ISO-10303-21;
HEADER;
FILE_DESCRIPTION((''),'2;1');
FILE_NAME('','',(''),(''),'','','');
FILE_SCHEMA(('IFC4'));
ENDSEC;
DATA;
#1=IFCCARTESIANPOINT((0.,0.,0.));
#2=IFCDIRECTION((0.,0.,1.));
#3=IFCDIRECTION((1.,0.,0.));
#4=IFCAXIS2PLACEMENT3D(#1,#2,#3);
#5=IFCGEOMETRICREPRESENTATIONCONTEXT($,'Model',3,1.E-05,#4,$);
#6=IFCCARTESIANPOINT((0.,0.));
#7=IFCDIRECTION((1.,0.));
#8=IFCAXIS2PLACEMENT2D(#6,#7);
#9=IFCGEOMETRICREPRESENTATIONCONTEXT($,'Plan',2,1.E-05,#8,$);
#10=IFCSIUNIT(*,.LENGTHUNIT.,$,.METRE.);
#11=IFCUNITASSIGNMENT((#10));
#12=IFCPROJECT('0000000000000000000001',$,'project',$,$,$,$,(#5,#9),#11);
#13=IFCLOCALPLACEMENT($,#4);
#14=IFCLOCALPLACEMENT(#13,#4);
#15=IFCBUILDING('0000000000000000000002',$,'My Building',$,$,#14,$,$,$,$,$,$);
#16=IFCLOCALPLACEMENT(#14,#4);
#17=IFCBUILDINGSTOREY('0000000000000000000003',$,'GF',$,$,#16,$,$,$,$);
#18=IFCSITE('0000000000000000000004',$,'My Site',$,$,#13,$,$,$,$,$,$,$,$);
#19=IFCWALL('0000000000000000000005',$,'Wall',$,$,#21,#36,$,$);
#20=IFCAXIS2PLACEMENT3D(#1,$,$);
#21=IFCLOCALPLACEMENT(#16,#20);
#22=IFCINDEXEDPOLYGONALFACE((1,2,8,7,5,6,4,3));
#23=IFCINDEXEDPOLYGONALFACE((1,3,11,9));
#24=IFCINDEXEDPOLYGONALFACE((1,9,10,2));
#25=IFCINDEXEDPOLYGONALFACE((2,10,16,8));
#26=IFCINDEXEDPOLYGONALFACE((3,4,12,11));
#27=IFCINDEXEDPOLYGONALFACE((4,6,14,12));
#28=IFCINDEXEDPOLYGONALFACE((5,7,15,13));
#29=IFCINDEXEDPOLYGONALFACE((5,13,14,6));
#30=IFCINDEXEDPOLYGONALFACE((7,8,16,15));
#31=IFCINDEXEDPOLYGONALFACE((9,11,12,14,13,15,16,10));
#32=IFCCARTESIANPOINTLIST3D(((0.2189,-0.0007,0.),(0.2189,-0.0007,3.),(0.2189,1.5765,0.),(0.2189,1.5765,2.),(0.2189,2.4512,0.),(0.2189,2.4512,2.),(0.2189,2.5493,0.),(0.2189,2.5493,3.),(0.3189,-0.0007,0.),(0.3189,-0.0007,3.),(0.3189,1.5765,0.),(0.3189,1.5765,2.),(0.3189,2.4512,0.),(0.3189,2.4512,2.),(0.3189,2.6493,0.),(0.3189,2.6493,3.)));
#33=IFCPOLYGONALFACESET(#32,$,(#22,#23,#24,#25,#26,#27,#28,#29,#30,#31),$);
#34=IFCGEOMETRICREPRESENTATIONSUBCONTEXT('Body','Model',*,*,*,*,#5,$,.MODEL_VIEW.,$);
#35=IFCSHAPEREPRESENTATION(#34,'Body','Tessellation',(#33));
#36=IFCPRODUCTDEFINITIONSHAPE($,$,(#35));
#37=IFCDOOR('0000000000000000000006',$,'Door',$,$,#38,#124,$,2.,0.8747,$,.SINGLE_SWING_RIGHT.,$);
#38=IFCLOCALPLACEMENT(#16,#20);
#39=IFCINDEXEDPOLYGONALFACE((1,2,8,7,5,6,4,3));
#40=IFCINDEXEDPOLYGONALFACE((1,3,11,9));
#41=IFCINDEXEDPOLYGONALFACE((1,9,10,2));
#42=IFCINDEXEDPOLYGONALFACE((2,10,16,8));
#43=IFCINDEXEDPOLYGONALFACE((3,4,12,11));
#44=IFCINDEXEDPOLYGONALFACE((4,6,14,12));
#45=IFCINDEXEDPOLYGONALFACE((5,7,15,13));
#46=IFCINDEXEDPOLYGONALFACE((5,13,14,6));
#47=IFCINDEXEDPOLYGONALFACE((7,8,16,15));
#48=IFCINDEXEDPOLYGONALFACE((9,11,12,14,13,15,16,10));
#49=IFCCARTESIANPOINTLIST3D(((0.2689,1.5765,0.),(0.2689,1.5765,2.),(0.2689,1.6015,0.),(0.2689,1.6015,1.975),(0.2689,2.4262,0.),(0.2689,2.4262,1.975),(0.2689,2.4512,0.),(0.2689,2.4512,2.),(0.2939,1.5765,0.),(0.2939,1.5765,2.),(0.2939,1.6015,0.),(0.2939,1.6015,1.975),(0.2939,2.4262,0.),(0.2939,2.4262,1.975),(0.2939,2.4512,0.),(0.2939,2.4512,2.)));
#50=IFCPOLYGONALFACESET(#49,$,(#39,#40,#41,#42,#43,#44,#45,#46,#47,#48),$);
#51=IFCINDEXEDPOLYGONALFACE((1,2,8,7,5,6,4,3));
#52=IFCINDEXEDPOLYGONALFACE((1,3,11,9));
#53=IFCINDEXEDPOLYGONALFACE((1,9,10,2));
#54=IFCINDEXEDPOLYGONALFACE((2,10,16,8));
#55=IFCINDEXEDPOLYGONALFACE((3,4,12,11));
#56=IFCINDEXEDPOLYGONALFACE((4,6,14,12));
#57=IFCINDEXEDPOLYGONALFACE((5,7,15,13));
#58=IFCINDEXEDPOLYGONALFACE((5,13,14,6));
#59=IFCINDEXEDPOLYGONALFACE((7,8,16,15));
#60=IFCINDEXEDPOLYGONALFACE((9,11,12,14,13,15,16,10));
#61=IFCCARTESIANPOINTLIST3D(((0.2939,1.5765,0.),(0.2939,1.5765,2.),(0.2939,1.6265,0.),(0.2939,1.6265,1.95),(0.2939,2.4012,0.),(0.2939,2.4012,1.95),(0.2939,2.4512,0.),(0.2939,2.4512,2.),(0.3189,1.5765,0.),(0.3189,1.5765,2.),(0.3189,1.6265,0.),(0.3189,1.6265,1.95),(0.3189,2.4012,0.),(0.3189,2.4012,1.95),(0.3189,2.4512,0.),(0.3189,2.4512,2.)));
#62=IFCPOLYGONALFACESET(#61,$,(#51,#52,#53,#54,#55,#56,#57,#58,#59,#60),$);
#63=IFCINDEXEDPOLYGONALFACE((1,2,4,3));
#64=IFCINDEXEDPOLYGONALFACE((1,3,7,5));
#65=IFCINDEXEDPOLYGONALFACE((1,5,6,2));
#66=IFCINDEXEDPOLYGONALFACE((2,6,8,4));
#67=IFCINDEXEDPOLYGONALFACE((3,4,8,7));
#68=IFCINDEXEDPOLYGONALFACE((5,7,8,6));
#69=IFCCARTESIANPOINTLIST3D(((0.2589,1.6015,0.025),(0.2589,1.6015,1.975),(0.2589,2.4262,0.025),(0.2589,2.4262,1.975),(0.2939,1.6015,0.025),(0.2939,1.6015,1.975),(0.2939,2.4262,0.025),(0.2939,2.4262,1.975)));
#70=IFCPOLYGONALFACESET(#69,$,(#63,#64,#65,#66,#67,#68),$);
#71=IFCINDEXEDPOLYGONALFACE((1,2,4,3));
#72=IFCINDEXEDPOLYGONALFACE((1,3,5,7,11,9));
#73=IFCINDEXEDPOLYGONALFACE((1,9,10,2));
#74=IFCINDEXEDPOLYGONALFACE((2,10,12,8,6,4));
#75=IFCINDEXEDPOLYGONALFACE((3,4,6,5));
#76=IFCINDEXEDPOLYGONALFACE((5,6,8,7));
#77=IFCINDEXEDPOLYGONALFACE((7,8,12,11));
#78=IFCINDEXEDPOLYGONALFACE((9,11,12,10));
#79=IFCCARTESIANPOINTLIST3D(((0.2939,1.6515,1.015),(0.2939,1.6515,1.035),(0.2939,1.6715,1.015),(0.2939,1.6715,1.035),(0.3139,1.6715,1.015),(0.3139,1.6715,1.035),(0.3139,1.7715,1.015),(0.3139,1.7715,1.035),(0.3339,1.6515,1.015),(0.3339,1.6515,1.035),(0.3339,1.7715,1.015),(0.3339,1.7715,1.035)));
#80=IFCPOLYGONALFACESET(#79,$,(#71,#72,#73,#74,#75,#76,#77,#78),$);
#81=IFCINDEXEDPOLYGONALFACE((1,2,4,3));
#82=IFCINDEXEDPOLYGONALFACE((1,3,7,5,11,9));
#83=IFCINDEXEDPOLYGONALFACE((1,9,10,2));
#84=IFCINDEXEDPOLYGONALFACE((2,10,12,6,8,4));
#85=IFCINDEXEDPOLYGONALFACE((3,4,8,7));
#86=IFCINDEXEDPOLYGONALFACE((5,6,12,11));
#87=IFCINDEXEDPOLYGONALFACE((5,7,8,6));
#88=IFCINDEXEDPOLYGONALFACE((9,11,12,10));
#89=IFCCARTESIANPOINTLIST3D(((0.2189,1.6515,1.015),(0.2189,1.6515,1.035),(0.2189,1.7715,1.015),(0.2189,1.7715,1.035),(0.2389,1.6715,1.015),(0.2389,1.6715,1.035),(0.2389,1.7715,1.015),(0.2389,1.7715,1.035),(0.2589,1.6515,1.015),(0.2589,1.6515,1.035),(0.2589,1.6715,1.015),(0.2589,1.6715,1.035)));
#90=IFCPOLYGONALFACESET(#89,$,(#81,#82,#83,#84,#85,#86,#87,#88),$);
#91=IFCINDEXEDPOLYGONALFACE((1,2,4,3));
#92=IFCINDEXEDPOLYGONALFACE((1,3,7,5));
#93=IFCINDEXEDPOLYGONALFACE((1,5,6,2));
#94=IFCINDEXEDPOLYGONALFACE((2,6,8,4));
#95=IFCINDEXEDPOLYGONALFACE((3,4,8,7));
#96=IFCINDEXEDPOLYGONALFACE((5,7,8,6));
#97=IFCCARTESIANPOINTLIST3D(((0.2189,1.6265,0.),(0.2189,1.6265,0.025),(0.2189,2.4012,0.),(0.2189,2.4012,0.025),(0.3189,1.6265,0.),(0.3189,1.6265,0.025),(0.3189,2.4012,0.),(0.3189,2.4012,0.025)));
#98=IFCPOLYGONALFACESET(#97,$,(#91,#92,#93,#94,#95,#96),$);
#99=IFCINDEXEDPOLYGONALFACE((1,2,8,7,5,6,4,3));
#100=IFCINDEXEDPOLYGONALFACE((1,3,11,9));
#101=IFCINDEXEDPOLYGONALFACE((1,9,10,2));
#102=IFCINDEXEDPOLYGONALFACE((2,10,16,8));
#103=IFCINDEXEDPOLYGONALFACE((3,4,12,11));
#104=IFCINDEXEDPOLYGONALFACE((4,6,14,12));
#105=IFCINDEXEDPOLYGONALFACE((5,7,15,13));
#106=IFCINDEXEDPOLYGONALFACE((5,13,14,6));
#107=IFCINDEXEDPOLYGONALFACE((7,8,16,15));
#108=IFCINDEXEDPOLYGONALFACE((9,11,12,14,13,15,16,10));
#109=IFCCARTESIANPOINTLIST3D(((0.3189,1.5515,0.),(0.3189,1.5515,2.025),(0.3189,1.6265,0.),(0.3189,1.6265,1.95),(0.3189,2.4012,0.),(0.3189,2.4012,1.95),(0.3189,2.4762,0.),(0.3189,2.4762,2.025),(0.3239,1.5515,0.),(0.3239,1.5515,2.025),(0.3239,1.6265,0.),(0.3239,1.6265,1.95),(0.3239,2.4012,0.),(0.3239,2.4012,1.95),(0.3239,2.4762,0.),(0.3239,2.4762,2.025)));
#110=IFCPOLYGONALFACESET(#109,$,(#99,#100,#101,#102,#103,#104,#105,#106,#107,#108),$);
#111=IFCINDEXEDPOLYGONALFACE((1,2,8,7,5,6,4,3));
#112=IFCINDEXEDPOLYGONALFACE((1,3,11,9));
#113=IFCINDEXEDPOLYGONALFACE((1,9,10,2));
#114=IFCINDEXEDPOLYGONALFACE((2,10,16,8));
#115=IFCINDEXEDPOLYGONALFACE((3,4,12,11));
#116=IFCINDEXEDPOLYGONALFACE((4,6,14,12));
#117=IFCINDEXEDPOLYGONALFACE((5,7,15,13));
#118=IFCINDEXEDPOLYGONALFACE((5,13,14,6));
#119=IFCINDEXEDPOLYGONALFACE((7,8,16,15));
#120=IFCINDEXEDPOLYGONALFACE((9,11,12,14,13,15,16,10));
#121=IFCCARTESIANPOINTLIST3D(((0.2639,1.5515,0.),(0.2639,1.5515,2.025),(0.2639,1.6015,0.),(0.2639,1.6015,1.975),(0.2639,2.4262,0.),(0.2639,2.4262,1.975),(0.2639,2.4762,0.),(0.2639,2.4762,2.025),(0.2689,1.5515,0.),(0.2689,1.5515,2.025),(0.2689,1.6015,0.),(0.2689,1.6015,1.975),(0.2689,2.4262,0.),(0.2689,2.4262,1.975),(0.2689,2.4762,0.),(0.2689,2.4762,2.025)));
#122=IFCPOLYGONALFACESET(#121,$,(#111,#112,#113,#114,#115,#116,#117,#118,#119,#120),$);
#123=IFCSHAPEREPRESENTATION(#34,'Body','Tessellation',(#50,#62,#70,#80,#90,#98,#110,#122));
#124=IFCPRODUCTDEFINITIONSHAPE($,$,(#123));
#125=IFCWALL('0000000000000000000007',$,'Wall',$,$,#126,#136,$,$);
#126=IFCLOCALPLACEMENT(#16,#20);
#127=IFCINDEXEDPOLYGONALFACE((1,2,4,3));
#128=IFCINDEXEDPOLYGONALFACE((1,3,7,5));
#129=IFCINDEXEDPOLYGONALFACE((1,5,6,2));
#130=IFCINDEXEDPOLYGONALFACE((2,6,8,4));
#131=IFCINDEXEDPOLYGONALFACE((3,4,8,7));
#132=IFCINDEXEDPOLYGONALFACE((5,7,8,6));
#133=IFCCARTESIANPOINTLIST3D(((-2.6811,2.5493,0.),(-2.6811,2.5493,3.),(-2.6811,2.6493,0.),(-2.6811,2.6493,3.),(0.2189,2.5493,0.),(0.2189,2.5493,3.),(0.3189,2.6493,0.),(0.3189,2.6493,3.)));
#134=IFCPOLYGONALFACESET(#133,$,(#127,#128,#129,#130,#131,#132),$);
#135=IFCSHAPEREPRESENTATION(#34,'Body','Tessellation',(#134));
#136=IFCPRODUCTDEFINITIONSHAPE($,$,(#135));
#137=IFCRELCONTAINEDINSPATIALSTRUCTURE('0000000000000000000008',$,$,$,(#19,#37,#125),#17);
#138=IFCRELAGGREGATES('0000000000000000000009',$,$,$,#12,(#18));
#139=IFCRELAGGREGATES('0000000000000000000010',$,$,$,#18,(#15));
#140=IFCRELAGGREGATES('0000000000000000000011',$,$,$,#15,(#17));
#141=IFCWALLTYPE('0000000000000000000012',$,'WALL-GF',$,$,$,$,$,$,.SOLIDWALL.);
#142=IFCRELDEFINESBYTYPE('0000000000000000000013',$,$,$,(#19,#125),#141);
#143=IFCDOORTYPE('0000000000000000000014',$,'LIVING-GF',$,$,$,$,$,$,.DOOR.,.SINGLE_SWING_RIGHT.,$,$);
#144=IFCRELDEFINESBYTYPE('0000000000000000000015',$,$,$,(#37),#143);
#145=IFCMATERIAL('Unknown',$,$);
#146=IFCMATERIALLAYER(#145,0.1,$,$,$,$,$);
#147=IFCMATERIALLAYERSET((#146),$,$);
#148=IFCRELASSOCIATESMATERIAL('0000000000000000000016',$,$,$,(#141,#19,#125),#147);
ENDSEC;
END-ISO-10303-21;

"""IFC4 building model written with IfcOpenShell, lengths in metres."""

from ifc_helpers import new_model, entity, si_unit, frame, origin_with_axes, origin_2d_with_axis, place, context, subcontext, project, spatial, line, indexed_curve, outline, extrude, shape, source, transform, mapped, material, layer, layer_set, layer_usage, type_object, type_shapes, element, fill, save


model = new_model("IFC4")

# Units and contexts
model_context = context("Model", 3, precision=1e-05, world=origin_with_axes())
plan_context = context("Plan", 2, precision=1e-05, world=origin_2d_with_axis())
body_context_1 = subcontext(model_context, "Body", "Model", "MODEL_VIEW")
body_context_2 = subcontext(plan_context, "Body", "Plan", "PLAN_VIEW")
ifc_project = project(units=[si_unit("LENGTHUNIT", "METRE")], contexts=[model_context, plan_context])

# Site, building, storey
site_placement = place(None, origin_with_axes())
site = spatial("IfcSite", under=ifc_project, at=site_placement, Name="My Site")
building_placement = place(site_placement, origin_with_axes())
building = spatial("IfcBuilding", under=site, at=building_placement, Name="My Building")
storey_placement = place(building_placement, origin_with_axes())
storey = spatial("IfcBuildingStorey", under=building, at=storey_placement, Name="GF")

# Shared definitions
ifc_material = material(Name="Unknown")

# Shared definitions
ifc_layer_1 = layer(ifc_material, 0.1)
ifc_layer_set_1 = layer_set([ifc_layer_1])
wall_type = type_object("IfcWallType", Name="WALL-GF", PredefinedType="SOLIDWALL", material=ifc_layer_set_1)

# Wall, opening, door
ifc_layer_usage_1 = layer_usage(ifc_layer_set_1, "AXIS2", "POSITIVE", 0.0)
wall_1_placement = place(storey_placement, frame((0.3189, -0.0007, 0.0), z_axis=(0.0, 0.0, 1.0), x_axis=(0.0, 1.0, 0.0)))
wall_1 = element("IfcWall", 1, at=wall_1_placement, inside=storey, type_object=wall_type, material=ifc_layer_usage_1, Name="Wall", context=body_context_1, shape_type="SweptSolid", body=[
    extrude(outline(indexed_curve([(0.0, 0.0), (0.0, 0.1), (2.55, 0.1), (2.65, 0.0)], segments=[line(1, 2, 3, 4, 1)])), origin_with_axes(), (0.0, 0.0, 1.0), 3.0),
])
shared_shape_1 = source(origin_with_axes(), body_context_1, "Body", "SweptSolid", [
    extrude(outline(indexed_curve([(0.0, 0.0), (0.8747, 0.0), (0.8747, 2.0), (0.0, 2.0)], segments=[line(1, 2, 3, 4, 1)])), frame((0.0, -0.6, 0.0), z_axis=(0.0, -1.0, 0.0), x_axis=(1.0, 0.0, 0.0)), (0.0, 0.0, -1.0), 1.2),
])
opening_1_placement = place(wall_1_placement, frame((1.5772, 0.0, 0.0), z_axis=(0.0, 0.0, 1.0), x_axis=(1.0, 0.0, 0.0)))
opening_1 = element("IfcOpeningElement", 2, at=opening_1_placement, cuts=wall_1, PredefinedType="OPENING", context=body_context_1, shape_type="MappedRepresentation", body=[
    mapped(shared_shape_1, transform((0.0, 0.0, 0.0), x_axis=(1.0, 0.0, 0.0), y_axis=(0.0, 1.0, 0.0), z_axis=(0.0, 0.0, 1.0), scale=1.0)),
])
door_type_1 = type_object("IfcDoorType", Name="LIVING-GF", OperationType="SINGLE_SWING_RIGHT", PredefinedType="DOOR")
shared_shape_2 = source(origin_with_axes(), body_context_1, "Body", "SweptSolid", [
    extrude(outline(indexed_curve([(0.0, 0.0), (0.0, 2.0), (0.8747, 2.0), (0.8747, 0.0), (0.8497, 0.0), (0.8497, 1.975), (0.025, 1.975), (0.025, 0.0)], segments=[line(1, 2, 3, 4, 5, 6, 7, 8, 1)])), frame((0.0, 0.025, 0.0), z_axis=(0.0, -1.0, 0.0), x_axis=(1.0, 0.0, 0.0)), (0.0, 0.0, -1.0), 0.025),
    extrude(outline(indexed_curve([(0.0, 0.0), (0.0, 2.0), (0.8747, 2.0), (0.8747, 0.0), (0.8247, 0.0), (0.8247, 1.95), (0.05, 1.95), (0.05, 0.0)], segments=[line(1, 2, 3, 4, 5, 6, 7, 8, 1)])), frame((0.0, 0.0, 0.0), z_axis=(0.0, -1.0, 0.0), x_axis=(1.0, 0.0, 0.0)), (0.0, 0.0, -1.0), 0.025),
    extrude(outline(indexed_curve([(0.0, 0.0), (0.8247, 0.0), (0.8247, 0.035), (0.0, 0.035)], segments=[line(1, 2, 3, 4, 1)])), frame((0.025, 0.025, 0.025), z_axis=(0.0, 0.0, 1.0), x_axis=(1.0, 0.0, 0.0)), (0.0, 0.0, 1.0), 1.95),
    extrude(outline(indexed_curve([(0.0, 0.0), (0.0, -0.04), (0.12, -0.04), (0.12, -0.02), (0.02, -0.02), (0.02, 0.0)], segments=[line(1, 2, 3, 4, 5, 6, 1)])), frame((0.075, 0.025, 1.015), z_axis=(0.0, 0.0, 1.0), x_axis=(1.0, 0.0, 0.0)), (0.0, 0.0, 1.0), 0.02),
    extrude(outline(indexed_curve([(0.0, 0.0), (0.0, 0.04), (0.12, 0.04), (0.12, 0.02), (0.02, 0.02), (0.02, 0.0)], segments=[line(1, 2, 3, 4, 5, 6, 1)])), frame((0.075, 0.06, 1.015), z_axis=(0.0, 0.0, 1.0), x_axis=(1.0, 0.0, 0.0)), (0.0, 0.0, 1.0), 0.02),
    extrude(outline(indexed_curve([(0.0, 0.0), (0.7747, 0.0), (0.7747, 0.1), (0.0, 0.1)], segments=[line(1, 2, 3, 4, 1)])), frame((0.05, 0.0, 0.0), z_axis=(0.0, 0.0, 1.0), x_axis=(1.0, 0.0, 0.0)), (0.0, 0.0, 1.0), 0.025),
    extrude(outline(indexed_curve([(0.0, 0.0), (0.0, 2.025), (0.9247, 2.025), (0.9247, 0.0), (0.8497, 0.0), (0.8497, 1.95), (0.075, 1.95), (0.075, 0.0)], segments=[line(1, 2, 3, 4, 5, 6, 7, 8, 1)])), frame((-0.025, -0.005, 0.0), z_axis=(0.0, -1.0, 0.0), x_axis=(1.0, 0.0, 0.0)), (0.0, 0.0, -1.0), 0.005),
    extrude(outline(indexed_curve([(0.0, 0.0), (0.0, 2.025), (0.9247, 2.025), (0.9247, 0.0), (0.8747, 0.0), (0.8747, 1.975), (0.05, 1.975), (0.05, 0.0)], segments=[line(1, 2, 3, 4, 5, 6, 7, 8, 1)])), frame((-0.025, 0.05, 0.0), z_axis=(0.0, -1.0, 0.0), x_axis=(1.0, 0.0, 0.0)), (0.0, 0.0, -1.0), 0.005),
])
shared_shape_3 = source(origin_with_axes(), body_context_2, "Body", "Curve2D", [
    entity("IfcIndexedPolyCurve", entity("IfcCartesianPointList2D", [[0.0, 0.0], [0.0, 0.05], [0.025, 0.05], [0.025, 0.025], [0.05, 0.025], [0.05, 0.0]]), [entity("IfcLineIndex", [1, 2, 3, 4, 5, 6, 1])]),
    entity("IfcIndexedPolyCurve", entity("IfcCartesianPointList2D", [[0.8747, 0.0], [0.8747, 0.05], [0.8497, 0.05], [0.8497, 0.025], [0.8247, 0.025], [0.8247, 0.0]]), [entity("IfcLineIndex", [1, 2, 3, 4, 5, 6, 1])]),
    entity("IfcTrimmedCurve", entity("IfcEllipse", entity("IfcAxis2Placement2D", entity("IfcCartesianPoint", [0.8147, 0.05]), entity("IfcDirection", [1.0, 0.0])), 0.7897, 0.8247), [entity("IfcCartesianPoint", [0.8147, 0.8747])], [entity("IfcCartesianPoint", [0.025, 0.05])], True, "CARTESIAN"),
    entity("IfcIndexedPolyCurve", entity("IfcCartesianPointList2D", [[0.8497, 0.05], [0.8147, 0.05], [0.8147, 0.8747], [0.8497, 0.8747]]), [entity("IfcLineIndex", [1, 2, 3, 4, 1])]),
])
type_shapes(door_type_1, [shared_shape_2, shared_shape_3])
door_1_placement = place(opening_1_placement, frame((0.0, 0.0, 0.0), z_axis=(0.0, 0.0, 1.0), x_axis=(1.0, 0.0, 0.0)))
door_1 = element("IfcDoor", 3, at=door_1_placement, inside=storey, type_object=door_type_1, Name="Door", OperationType="SINGLE_SWING_RIGHT", OverallHeight=2.0, OverallWidth=0.8747, shapes=[
    shape(body_context_1, "Body", "MappedRepresentation", [mapped(shared_shape_2, transform((0.0, 0.0, 0.0), x_axis=(1.0, 0.0, 0.0), y_axis=(0.0, 1.0, 0.0), z_axis=(0.0, 0.0, 1.0), scale=1.0))]),
    shape(body_context_2, "Body", "MappedRepresentation", [mapped(shared_shape_3, transform((0.0, 0.0, 0.0), x_axis=(1.0, 0.0, 0.0), y_axis=(0.0, 1.0, 0.0), z_axis=(0.0, 0.0, 1.0), scale=1.0))]),
])
fill(opening_1, door_1)

# Wall
ifc_layer_usage_2 = layer_usage(ifc_layer_set_1, "AXIS2", "POSITIVE", 0.0)
wall_2_placement = place(storey_placement, frame((0.3189, 2.6493, 0.0), z_axis=(0.0, 0.0, 1.0), x_axis=(-1.0, 0.0, 0.0)))
element("IfcWall", 4, at=wall_2_placement, inside=storey, type_object=wall_type, material=ifc_layer_usage_2, Name="Wall", context=body_context_1, shape_type="SweptSolid", body=[
    extrude(outline(indexed_curve([(0.0, 0.0), (0.1, 0.1), (3.0, 0.1), (3.0, 0.0)], segments=[line(1, 2, 3, 4, 1)])), origin_with_axes(), (0.0, 0.0, 1.0), 3.0),
])

save(model, "model.ifc")
